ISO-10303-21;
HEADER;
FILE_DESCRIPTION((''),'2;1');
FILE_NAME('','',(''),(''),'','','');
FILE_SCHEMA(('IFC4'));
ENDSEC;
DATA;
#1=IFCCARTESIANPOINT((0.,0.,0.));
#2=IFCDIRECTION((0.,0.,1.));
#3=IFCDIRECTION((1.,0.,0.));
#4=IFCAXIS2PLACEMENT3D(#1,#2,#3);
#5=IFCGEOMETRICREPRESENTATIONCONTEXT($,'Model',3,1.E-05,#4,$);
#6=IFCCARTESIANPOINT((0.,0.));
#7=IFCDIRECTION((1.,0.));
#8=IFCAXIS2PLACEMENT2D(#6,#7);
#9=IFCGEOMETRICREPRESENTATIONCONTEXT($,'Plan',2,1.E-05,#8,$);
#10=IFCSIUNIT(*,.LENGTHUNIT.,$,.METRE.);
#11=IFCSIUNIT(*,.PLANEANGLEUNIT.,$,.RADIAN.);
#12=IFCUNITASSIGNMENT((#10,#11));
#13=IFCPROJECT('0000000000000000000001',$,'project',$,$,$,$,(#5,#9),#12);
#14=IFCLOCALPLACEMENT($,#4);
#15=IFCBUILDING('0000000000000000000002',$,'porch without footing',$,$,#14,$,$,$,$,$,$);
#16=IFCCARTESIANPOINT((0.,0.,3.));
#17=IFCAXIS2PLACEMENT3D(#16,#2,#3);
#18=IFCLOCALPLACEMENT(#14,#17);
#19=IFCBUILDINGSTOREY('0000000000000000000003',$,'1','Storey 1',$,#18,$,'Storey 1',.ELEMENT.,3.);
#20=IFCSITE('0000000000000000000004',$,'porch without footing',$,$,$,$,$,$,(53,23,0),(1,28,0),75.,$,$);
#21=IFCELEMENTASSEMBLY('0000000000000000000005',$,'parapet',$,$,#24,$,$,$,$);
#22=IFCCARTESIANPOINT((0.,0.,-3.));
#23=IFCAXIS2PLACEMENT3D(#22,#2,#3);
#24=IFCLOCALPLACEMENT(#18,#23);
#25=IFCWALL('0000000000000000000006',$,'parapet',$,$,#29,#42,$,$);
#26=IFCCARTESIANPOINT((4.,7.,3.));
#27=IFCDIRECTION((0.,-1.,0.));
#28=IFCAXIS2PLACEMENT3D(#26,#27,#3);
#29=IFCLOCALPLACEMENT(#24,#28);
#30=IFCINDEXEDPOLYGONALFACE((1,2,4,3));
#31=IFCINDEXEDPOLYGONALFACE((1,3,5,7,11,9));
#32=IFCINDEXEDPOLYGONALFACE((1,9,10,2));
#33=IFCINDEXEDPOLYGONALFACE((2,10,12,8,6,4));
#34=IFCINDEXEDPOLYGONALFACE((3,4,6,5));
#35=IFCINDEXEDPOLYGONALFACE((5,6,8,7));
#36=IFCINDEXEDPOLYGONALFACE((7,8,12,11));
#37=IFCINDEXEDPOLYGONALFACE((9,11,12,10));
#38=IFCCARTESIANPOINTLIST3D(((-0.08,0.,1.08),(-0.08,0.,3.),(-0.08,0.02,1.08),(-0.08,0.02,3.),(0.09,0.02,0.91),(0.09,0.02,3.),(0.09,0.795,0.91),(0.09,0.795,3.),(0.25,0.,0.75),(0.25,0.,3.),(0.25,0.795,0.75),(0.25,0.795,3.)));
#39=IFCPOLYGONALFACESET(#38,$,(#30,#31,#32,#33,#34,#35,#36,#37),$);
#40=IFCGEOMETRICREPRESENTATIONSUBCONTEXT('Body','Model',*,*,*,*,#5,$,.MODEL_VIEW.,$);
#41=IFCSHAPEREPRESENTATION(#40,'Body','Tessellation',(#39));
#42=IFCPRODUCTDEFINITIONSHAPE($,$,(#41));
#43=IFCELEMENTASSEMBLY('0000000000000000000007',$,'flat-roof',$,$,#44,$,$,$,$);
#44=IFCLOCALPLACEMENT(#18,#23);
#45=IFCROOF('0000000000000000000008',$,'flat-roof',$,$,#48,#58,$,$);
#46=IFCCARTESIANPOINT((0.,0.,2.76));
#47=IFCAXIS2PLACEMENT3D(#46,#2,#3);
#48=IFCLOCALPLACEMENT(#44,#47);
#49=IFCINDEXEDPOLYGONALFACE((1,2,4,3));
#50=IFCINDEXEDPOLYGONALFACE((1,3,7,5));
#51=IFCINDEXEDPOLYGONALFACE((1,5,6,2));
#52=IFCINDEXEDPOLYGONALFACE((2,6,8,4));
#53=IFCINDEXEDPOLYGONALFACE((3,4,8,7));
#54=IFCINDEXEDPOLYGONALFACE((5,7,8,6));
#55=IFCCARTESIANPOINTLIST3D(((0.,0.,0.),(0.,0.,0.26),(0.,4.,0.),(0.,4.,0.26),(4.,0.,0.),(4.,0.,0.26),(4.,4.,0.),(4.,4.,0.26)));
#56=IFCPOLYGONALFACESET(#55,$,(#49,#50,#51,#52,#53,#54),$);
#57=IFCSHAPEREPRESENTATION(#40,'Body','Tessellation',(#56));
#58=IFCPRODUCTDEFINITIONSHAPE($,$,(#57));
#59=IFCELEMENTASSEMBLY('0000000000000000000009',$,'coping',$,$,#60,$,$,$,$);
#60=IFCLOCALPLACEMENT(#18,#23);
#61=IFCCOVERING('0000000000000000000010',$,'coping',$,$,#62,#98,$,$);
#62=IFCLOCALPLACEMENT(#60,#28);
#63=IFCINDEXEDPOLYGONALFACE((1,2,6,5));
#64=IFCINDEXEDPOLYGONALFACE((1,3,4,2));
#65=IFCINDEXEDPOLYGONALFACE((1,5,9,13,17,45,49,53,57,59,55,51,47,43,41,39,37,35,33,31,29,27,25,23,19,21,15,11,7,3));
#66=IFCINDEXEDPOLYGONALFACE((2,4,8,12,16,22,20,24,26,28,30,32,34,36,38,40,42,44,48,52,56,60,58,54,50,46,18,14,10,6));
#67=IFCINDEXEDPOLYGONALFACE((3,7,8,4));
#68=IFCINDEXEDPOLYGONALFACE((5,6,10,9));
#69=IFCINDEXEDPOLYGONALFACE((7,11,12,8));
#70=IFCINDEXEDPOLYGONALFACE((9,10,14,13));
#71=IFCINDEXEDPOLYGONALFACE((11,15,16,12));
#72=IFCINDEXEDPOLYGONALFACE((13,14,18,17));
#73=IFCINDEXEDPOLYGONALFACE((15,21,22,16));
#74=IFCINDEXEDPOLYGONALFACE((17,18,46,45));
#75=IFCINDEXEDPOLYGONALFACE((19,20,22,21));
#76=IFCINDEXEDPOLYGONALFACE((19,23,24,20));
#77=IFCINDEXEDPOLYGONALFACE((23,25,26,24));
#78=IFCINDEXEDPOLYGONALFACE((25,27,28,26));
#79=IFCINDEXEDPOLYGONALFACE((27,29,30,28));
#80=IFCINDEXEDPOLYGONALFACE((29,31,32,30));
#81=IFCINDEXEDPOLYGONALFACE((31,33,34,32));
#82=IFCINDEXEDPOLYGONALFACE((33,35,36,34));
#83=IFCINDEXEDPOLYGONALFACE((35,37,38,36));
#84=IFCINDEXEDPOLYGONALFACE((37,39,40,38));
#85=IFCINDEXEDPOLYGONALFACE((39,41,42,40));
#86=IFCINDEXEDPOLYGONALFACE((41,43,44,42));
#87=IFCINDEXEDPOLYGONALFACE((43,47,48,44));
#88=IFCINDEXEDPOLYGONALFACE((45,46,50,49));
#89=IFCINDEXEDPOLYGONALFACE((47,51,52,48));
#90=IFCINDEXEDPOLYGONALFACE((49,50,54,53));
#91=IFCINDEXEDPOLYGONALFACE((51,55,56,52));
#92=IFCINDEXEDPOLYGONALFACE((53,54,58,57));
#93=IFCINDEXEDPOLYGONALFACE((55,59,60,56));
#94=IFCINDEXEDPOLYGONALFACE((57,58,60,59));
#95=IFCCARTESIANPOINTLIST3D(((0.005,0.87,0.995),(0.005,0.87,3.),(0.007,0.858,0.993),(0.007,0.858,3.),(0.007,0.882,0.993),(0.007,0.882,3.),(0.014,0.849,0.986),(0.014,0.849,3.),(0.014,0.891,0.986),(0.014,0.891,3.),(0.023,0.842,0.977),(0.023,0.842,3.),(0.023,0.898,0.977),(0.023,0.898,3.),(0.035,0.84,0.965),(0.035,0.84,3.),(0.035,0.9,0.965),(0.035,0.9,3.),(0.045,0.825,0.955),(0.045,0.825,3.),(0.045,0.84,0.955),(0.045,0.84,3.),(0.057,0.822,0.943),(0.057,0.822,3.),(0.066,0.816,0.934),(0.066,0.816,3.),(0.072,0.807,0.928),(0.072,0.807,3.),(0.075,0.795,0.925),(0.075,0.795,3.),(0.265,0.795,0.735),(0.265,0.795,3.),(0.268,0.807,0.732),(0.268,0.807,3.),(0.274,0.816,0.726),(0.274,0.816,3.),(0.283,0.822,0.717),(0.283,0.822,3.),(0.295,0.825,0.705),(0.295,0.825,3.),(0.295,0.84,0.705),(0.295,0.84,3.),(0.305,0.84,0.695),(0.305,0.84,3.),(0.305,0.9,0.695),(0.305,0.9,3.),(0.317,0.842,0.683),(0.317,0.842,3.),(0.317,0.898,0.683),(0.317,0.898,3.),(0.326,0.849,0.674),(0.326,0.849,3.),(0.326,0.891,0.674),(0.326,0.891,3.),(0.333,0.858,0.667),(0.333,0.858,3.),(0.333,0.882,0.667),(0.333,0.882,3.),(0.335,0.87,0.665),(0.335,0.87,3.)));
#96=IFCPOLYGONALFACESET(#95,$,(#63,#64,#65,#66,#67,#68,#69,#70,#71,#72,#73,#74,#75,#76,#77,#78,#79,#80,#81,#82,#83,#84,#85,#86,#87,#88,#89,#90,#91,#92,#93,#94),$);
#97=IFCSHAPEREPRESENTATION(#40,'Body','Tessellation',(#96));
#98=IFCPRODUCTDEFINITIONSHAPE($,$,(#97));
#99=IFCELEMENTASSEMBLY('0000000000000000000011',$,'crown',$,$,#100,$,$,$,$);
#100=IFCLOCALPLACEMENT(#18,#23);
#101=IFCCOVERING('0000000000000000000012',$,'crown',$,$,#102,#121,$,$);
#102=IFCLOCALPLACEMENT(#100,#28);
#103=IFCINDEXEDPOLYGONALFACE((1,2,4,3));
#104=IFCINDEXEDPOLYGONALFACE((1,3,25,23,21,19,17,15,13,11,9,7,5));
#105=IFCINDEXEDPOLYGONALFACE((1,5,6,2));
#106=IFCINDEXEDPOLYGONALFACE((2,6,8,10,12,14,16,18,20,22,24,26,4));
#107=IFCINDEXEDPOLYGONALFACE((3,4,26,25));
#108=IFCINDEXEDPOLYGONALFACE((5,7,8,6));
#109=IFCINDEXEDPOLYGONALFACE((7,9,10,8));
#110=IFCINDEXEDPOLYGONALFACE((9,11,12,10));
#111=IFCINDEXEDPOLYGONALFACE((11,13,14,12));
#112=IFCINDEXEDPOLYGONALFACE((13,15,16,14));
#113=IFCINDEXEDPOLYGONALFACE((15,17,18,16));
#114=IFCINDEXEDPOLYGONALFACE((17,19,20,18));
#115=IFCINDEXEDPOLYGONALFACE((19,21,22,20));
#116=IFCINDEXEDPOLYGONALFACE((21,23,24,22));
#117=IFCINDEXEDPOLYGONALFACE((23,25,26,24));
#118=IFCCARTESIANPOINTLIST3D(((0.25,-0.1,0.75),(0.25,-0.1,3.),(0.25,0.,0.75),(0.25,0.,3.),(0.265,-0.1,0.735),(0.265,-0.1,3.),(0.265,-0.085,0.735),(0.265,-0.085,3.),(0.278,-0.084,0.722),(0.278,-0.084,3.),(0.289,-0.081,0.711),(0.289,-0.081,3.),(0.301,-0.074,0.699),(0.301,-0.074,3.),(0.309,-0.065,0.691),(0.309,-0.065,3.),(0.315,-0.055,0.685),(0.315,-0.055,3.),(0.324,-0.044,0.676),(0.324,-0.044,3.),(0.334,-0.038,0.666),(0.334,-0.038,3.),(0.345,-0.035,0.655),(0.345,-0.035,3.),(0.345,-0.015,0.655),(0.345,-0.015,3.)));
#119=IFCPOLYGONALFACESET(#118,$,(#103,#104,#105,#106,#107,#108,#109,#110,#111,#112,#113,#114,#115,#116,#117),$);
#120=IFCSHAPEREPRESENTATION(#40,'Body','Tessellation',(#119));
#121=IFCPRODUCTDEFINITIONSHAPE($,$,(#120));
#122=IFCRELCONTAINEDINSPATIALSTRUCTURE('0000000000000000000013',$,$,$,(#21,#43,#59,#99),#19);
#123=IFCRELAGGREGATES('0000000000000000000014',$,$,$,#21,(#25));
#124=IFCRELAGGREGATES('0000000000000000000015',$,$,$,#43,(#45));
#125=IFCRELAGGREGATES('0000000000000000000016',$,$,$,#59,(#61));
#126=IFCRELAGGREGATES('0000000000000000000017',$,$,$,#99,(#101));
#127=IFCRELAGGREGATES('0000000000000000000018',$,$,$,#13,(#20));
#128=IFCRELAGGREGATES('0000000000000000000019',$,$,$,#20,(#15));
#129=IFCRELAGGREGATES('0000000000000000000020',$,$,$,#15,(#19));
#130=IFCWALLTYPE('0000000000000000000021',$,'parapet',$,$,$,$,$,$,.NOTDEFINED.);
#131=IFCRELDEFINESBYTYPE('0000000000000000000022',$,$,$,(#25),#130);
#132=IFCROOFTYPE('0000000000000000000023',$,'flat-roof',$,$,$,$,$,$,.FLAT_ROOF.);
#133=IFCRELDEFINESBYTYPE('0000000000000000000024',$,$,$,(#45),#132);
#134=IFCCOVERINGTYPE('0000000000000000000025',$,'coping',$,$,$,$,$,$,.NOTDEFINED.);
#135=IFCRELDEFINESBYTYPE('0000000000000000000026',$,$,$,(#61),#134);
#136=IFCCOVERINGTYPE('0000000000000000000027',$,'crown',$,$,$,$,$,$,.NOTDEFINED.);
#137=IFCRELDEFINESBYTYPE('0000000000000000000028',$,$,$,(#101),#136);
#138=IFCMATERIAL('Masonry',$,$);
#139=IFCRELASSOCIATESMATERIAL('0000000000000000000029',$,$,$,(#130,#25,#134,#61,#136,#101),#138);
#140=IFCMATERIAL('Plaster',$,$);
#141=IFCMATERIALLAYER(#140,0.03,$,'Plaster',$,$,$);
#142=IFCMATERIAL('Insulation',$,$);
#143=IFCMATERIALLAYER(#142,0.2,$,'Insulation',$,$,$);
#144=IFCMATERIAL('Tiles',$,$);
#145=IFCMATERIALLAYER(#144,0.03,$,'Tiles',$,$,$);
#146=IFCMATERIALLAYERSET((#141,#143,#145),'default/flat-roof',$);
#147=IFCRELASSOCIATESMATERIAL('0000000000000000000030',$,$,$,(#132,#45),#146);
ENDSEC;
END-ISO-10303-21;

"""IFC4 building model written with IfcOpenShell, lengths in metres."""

from ifc_helpers import new_model, si_unit, frame, origin, origin_with_axes, origin_2d_with_axis, place, context, subcontext, project, spatial, polyline, outline, extrude, clip, halfspace, material, layer, layer_set, layer_usage, material_profile, profile_set, profile_usage, type_object, element, aggregate, save


model = new_model("IFC4")

# Units and contexts
model_context = context("Model", 3, precision=1e-05, world=origin_with_axes())
plan_context = context("Plan", 2, precision=1e-05, world=origin_2d_with_axis())
body_context = subcontext(model_context, "Body", "Model", "MODEL_VIEW")
ifc_project = project(units=[si_unit("LENGTHUNIT", "METRE"), si_unit("PLANEANGLEUNIT", "RADIAN")], contexts=[model_context, plan_context])

# Site, building, storey
site = spatial("IfcSite", under=ifc_project, Name="porch without footing", RefLatitude=(53, 23, 0), RefLongitude=(1, 28, 0), RefElevation=75.0)
building_placement = place(None, origin_with_axes())
building = spatial("IfcBuilding", under=site, at=building_placement, Name="porch without footing")
storey_placement = place(building_placement, frame((0.0, 0.0, 3.0), z_axis=(0.0, 0.0, 1.0), x_axis=(1.0, 0.0, 0.0)))
storey = spatial("IfcBuildingStorey", under=building, at=storey_placement, Name="1", Description="Storey 1", LongName="Storey 1", CompositionType="ELEMENT", Elevation=3.0)

# Element assembly, wall
assembly_1_placement = place(storey_placement, frame((0.0, 0.0, -3.0), z_axis=(0.0, 0.0, 1.0), x_axis=(1.0, 0.0, 0.0)))
assembly_1 = element("IfcElementAssembly", 1, at=assembly_1_placement, inside=storey, Name="parapet")
ifc_material_1 = material(Name="Masonry")
ifc_material_profile_1 = material_profile(ifc_material_1, outline(polyline([(0.25, 0.0), (0.25, 0.795), (0.09, 0.795), (0.09, 0.02), (-0.08, 0.02), (-0.08, 0.0), (0.25, 0.0)])))
ifc_profile_set_1 = profile_set([ifc_material_profile_1])
wall_type = type_object("IfcWallType", Name="parapet", PredefinedType="NOTDEFINED", material=ifc_profile_set_1)
ifc_profile_usage_1 = profile_usage(ifc_profile_set_1)
wall_1_placement = place(assembly_1_placement, frame((4.0, 7.0, 3.0), z_axis=(0.0, -1.0, 0.0), x_axis=(1.0, 0.0, 0.0)))
wall_1 = element("IfcWall", 2, at=wall_1_placement, type_object=wall_type, material=ifc_profile_usage_1, Name="parapet", context=body_context, shape_type="Clipping", body=[
    clip(clip(extrude(outline(polyline([(0.25, 0.0), (0.25, 0.795), (0.09, 0.795), (0.09, 0.02), (-0.08, 0.02), (-0.08, 0.0), (0.25, 0.0)])), origin_with_axes(), (0.0, 0.0, 1.0), 4.0), halfspace(frame((0.0, -3.0, 1.0), z_axis=(-0.707107, 0.0, -0.707107), x_axis=(0.0, 1.0, 0.0)), False)), halfspace(frame((0.0, -3.0, 3.0), z_axis=(0.0, 0.0, 1.0), x_axis=(-1.0, 0.0, 0.0)), False)),
])
aggregate(assembly_1, [wall_1])

# Element assembly, roof
assembly_2_placement = place(storey_placement, frame((0.0, 0.0, -3.0), z_axis=(0.0, 0.0, 1.0), x_axis=(1.0, 0.0, 0.0)))
assembly_2 = element("IfcElementAssembly", 3, at=assembly_2_placement, inside=storey, Name="flat-roof")
ifc_material_2 = material(Name="Plaster")
ifc_layer_1 = layer(ifc_material_2, 0.03, Name="Plaster")
ifc_material_3 = material(Name="Insulation")
ifc_layer_2 = layer(ifc_material_3, 0.2, Name="Insulation")
ifc_material_4 = material(Name="Tiles")
ifc_layer_3 = layer(ifc_material_4, 0.03, Name="Tiles")
ifc_layer_set = layer_set([ifc_layer_1, ifc_layer_2, ifc_layer_3], Name="default/flat-roof")
ifc_layer_usage_1 = layer_usage(ifc_layer_set, "AXIS3", "POSITIVE", 0.0)
roof_type = type_object("IfcRoofType", Name="flat-roof", PredefinedType="FLAT_ROOF", material=ifc_layer_set)
roof_1_placement = place(assembly_2_placement, frame((0.0, 0.0, 2.76), z_axis=(0.0, 0.0, 1.0), x_axis=(1.0, 0.0, 0.0)))
roof_1 = element("IfcRoof", 4, at=roof_1_placement, type_object=roof_type, material=ifc_layer_usage_1, Name="flat-roof", context=body_context, shape_type="SweptSolid", body=[
    extrude(outline(polyline([(0.0, 0.0), (4.0, 0.0), (4.0, 4.0), (0.0, 4.0), (0.0, 0.0)])), origin(), (0.0, 0.0, 1.0), 0.26),
])
aggregate(assembly_2, [roof_1])

# Element assemblies, coverings
assembly_3_placement = place(storey_placement, frame((0.0, 0.0, -3.0), z_axis=(0.0, 0.0, 1.0), x_axis=(1.0, 0.0, 0.0)))
assembly_3 = element("IfcElementAssembly", 5, at=assembly_3_placement, inside=storey, Name="coping")
ifc_material_profile_2 = material_profile(ifc_material_1, outline(polyline([(0.265, 0.795), (0.268, 0.807), (0.274, 0.816), (0.283, 0.822), (0.295, 0.825), (0.295, 0.84), (0.305, 0.84), (0.317, 0.842), (0.326, 0.849), (0.333, 0.858), (0.335, 0.87), (0.333, 0.882), (0.326, 0.891), (0.317, 0.898), (0.305, 0.9), (0.035, 0.9), (0.023, 0.898), (0.014, 0.891), (0.007, 0.882), (0.005, 0.87), (0.007, 0.858), (0.014, 0.849), (0.023, 0.842), (0.035, 0.84), (0.045, 0.84), (0.045, 0.825), (0.057, 0.822), (0.066, 0.816), (0.072, 0.807), (0.075, 0.795), (0.265, 0.795)])))
ifc_profile_set_2 = profile_set([ifc_material_profile_2])
covering_type_1 = type_object("IfcCoveringType", Name="coping", PredefinedType="NOTDEFINED", material=ifc_profile_set_2)
ifc_profile_usage_2 = profile_usage(ifc_profile_set_2)
covering_1_placement = place(assembly_3_placement, frame((4.0, 7.0, 3.0), z_axis=(0.0, -1.0, 0.0), x_axis=(1.0, 0.0, 0.0)))
covering_1 = element("IfcCovering", 6, at=covering_1_placement, type_object=covering_type_1, material=ifc_profile_usage_2, Name="coping", context=body_context, shape_type="Clipping", body=[
    clip(clip(extrude(outline(polyline([(0.265, 0.795), (0.268, 0.807), (0.274, 0.816), (0.283, 0.822), (0.295, 0.825), (0.295, 0.84), (0.305, 0.84), (0.317, 0.842), (0.326, 0.849), (0.333, 0.858), (0.335, 0.87), (0.333, 0.882), (0.326, 0.891), (0.317, 0.898), (0.305, 0.9), (0.035, 0.9), (0.023, 0.898), (0.014, 0.891), (0.007, 0.882), (0.005, 0.87), (0.007, 0.858), (0.014, 0.849), (0.023, 0.842), (0.035, 0.84), (0.045, 0.84), (0.045, 0.825), (0.057, 0.822), (0.066, 0.816), (0.072, 0.807), (0.075, 0.795), (0.265, 0.795)])), origin_with_axes(), (0.0, 0.0, 1.0), 4.0), halfspace(frame((0.0, -3.0, 1.0), z_axis=(-0.707107, 0.0, -0.707107), x_axis=(0.0, 1.0, 0.0)), False)), halfspace(frame((0.0, -3.0, 3.0), z_axis=(0.0, 0.0, 1.0), x_axis=(-1.0, 0.0, 0.0)), False)),
])
aggregate(assembly_3, [covering_1])
assembly_4_placement = place(storey_placement, frame((0.0, 0.0, -3.0), z_axis=(0.0, 0.0, 1.0), x_axis=(1.0, 0.0, 0.0)))
assembly_4 = element("IfcElementAssembly", 7, at=assembly_4_placement, inside=storey, Name="crown")
ifc_material_profile_3 = material_profile(ifc_material_1, outline(polyline([(0.25, -0.1), (0.265, -0.1), (0.265, -0.085), (0.278, -0.084), (0.289, -0.081), (0.301, -0.074), (0.309, -0.065), (0.315, -0.055), (0.324, -0.044), (0.334, -0.038), (0.345, -0.035), (0.345, -0.015), (0.25, 0.0), (0.25, -0.1)])))
ifc_profile_set_3 = profile_set([ifc_material_profile_3])
covering_type_2 = type_object("IfcCoveringType", Name="crown", PredefinedType="NOTDEFINED", material=ifc_profile_set_3)
ifc_profile_usage_3 = profile_usage(ifc_profile_set_3)
covering_2_placement = place(assembly_4_placement, frame((4.0, 7.0, 3.0), z_axis=(0.0, -1.0, 0.0), x_axis=(1.0, 0.0, 0.0)))
covering_2 = element("IfcCovering", 8, at=covering_2_placement, type_object=covering_type_2, material=ifc_profile_usage_3, Name="crown", context=body_context, shape_type="Clipping", body=[
    clip(clip(extrude(outline(polyline([(0.25, -0.1), (0.265, -0.1), (0.265, -0.085), (0.278, -0.084), (0.289, -0.081), (0.301, -0.074), (0.309, -0.065), (0.315, -0.055), (0.324, -0.044), (0.334, -0.038), (0.345, -0.035), (0.345, -0.015), (0.25, 0.0), (0.25, -0.1)])), origin_with_axes(), (0.0, 0.0, 1.0), 4.0), halfspace(frame((0.0, -3.0, 1.0), z_axis=(-0.707107, 0.0, -0.707107), x_axis=(0.0, 1.0, 0.0)), False)), halfspace(frame((0.0, -3.0, 3.0), z_axis=(0.0, 0.0, 1.0), x_axis=(-1.0, 0.0, 0.0)), False)),
])
aggregate(assembly_4, [covering_2])

save(model, "model.ifc")
